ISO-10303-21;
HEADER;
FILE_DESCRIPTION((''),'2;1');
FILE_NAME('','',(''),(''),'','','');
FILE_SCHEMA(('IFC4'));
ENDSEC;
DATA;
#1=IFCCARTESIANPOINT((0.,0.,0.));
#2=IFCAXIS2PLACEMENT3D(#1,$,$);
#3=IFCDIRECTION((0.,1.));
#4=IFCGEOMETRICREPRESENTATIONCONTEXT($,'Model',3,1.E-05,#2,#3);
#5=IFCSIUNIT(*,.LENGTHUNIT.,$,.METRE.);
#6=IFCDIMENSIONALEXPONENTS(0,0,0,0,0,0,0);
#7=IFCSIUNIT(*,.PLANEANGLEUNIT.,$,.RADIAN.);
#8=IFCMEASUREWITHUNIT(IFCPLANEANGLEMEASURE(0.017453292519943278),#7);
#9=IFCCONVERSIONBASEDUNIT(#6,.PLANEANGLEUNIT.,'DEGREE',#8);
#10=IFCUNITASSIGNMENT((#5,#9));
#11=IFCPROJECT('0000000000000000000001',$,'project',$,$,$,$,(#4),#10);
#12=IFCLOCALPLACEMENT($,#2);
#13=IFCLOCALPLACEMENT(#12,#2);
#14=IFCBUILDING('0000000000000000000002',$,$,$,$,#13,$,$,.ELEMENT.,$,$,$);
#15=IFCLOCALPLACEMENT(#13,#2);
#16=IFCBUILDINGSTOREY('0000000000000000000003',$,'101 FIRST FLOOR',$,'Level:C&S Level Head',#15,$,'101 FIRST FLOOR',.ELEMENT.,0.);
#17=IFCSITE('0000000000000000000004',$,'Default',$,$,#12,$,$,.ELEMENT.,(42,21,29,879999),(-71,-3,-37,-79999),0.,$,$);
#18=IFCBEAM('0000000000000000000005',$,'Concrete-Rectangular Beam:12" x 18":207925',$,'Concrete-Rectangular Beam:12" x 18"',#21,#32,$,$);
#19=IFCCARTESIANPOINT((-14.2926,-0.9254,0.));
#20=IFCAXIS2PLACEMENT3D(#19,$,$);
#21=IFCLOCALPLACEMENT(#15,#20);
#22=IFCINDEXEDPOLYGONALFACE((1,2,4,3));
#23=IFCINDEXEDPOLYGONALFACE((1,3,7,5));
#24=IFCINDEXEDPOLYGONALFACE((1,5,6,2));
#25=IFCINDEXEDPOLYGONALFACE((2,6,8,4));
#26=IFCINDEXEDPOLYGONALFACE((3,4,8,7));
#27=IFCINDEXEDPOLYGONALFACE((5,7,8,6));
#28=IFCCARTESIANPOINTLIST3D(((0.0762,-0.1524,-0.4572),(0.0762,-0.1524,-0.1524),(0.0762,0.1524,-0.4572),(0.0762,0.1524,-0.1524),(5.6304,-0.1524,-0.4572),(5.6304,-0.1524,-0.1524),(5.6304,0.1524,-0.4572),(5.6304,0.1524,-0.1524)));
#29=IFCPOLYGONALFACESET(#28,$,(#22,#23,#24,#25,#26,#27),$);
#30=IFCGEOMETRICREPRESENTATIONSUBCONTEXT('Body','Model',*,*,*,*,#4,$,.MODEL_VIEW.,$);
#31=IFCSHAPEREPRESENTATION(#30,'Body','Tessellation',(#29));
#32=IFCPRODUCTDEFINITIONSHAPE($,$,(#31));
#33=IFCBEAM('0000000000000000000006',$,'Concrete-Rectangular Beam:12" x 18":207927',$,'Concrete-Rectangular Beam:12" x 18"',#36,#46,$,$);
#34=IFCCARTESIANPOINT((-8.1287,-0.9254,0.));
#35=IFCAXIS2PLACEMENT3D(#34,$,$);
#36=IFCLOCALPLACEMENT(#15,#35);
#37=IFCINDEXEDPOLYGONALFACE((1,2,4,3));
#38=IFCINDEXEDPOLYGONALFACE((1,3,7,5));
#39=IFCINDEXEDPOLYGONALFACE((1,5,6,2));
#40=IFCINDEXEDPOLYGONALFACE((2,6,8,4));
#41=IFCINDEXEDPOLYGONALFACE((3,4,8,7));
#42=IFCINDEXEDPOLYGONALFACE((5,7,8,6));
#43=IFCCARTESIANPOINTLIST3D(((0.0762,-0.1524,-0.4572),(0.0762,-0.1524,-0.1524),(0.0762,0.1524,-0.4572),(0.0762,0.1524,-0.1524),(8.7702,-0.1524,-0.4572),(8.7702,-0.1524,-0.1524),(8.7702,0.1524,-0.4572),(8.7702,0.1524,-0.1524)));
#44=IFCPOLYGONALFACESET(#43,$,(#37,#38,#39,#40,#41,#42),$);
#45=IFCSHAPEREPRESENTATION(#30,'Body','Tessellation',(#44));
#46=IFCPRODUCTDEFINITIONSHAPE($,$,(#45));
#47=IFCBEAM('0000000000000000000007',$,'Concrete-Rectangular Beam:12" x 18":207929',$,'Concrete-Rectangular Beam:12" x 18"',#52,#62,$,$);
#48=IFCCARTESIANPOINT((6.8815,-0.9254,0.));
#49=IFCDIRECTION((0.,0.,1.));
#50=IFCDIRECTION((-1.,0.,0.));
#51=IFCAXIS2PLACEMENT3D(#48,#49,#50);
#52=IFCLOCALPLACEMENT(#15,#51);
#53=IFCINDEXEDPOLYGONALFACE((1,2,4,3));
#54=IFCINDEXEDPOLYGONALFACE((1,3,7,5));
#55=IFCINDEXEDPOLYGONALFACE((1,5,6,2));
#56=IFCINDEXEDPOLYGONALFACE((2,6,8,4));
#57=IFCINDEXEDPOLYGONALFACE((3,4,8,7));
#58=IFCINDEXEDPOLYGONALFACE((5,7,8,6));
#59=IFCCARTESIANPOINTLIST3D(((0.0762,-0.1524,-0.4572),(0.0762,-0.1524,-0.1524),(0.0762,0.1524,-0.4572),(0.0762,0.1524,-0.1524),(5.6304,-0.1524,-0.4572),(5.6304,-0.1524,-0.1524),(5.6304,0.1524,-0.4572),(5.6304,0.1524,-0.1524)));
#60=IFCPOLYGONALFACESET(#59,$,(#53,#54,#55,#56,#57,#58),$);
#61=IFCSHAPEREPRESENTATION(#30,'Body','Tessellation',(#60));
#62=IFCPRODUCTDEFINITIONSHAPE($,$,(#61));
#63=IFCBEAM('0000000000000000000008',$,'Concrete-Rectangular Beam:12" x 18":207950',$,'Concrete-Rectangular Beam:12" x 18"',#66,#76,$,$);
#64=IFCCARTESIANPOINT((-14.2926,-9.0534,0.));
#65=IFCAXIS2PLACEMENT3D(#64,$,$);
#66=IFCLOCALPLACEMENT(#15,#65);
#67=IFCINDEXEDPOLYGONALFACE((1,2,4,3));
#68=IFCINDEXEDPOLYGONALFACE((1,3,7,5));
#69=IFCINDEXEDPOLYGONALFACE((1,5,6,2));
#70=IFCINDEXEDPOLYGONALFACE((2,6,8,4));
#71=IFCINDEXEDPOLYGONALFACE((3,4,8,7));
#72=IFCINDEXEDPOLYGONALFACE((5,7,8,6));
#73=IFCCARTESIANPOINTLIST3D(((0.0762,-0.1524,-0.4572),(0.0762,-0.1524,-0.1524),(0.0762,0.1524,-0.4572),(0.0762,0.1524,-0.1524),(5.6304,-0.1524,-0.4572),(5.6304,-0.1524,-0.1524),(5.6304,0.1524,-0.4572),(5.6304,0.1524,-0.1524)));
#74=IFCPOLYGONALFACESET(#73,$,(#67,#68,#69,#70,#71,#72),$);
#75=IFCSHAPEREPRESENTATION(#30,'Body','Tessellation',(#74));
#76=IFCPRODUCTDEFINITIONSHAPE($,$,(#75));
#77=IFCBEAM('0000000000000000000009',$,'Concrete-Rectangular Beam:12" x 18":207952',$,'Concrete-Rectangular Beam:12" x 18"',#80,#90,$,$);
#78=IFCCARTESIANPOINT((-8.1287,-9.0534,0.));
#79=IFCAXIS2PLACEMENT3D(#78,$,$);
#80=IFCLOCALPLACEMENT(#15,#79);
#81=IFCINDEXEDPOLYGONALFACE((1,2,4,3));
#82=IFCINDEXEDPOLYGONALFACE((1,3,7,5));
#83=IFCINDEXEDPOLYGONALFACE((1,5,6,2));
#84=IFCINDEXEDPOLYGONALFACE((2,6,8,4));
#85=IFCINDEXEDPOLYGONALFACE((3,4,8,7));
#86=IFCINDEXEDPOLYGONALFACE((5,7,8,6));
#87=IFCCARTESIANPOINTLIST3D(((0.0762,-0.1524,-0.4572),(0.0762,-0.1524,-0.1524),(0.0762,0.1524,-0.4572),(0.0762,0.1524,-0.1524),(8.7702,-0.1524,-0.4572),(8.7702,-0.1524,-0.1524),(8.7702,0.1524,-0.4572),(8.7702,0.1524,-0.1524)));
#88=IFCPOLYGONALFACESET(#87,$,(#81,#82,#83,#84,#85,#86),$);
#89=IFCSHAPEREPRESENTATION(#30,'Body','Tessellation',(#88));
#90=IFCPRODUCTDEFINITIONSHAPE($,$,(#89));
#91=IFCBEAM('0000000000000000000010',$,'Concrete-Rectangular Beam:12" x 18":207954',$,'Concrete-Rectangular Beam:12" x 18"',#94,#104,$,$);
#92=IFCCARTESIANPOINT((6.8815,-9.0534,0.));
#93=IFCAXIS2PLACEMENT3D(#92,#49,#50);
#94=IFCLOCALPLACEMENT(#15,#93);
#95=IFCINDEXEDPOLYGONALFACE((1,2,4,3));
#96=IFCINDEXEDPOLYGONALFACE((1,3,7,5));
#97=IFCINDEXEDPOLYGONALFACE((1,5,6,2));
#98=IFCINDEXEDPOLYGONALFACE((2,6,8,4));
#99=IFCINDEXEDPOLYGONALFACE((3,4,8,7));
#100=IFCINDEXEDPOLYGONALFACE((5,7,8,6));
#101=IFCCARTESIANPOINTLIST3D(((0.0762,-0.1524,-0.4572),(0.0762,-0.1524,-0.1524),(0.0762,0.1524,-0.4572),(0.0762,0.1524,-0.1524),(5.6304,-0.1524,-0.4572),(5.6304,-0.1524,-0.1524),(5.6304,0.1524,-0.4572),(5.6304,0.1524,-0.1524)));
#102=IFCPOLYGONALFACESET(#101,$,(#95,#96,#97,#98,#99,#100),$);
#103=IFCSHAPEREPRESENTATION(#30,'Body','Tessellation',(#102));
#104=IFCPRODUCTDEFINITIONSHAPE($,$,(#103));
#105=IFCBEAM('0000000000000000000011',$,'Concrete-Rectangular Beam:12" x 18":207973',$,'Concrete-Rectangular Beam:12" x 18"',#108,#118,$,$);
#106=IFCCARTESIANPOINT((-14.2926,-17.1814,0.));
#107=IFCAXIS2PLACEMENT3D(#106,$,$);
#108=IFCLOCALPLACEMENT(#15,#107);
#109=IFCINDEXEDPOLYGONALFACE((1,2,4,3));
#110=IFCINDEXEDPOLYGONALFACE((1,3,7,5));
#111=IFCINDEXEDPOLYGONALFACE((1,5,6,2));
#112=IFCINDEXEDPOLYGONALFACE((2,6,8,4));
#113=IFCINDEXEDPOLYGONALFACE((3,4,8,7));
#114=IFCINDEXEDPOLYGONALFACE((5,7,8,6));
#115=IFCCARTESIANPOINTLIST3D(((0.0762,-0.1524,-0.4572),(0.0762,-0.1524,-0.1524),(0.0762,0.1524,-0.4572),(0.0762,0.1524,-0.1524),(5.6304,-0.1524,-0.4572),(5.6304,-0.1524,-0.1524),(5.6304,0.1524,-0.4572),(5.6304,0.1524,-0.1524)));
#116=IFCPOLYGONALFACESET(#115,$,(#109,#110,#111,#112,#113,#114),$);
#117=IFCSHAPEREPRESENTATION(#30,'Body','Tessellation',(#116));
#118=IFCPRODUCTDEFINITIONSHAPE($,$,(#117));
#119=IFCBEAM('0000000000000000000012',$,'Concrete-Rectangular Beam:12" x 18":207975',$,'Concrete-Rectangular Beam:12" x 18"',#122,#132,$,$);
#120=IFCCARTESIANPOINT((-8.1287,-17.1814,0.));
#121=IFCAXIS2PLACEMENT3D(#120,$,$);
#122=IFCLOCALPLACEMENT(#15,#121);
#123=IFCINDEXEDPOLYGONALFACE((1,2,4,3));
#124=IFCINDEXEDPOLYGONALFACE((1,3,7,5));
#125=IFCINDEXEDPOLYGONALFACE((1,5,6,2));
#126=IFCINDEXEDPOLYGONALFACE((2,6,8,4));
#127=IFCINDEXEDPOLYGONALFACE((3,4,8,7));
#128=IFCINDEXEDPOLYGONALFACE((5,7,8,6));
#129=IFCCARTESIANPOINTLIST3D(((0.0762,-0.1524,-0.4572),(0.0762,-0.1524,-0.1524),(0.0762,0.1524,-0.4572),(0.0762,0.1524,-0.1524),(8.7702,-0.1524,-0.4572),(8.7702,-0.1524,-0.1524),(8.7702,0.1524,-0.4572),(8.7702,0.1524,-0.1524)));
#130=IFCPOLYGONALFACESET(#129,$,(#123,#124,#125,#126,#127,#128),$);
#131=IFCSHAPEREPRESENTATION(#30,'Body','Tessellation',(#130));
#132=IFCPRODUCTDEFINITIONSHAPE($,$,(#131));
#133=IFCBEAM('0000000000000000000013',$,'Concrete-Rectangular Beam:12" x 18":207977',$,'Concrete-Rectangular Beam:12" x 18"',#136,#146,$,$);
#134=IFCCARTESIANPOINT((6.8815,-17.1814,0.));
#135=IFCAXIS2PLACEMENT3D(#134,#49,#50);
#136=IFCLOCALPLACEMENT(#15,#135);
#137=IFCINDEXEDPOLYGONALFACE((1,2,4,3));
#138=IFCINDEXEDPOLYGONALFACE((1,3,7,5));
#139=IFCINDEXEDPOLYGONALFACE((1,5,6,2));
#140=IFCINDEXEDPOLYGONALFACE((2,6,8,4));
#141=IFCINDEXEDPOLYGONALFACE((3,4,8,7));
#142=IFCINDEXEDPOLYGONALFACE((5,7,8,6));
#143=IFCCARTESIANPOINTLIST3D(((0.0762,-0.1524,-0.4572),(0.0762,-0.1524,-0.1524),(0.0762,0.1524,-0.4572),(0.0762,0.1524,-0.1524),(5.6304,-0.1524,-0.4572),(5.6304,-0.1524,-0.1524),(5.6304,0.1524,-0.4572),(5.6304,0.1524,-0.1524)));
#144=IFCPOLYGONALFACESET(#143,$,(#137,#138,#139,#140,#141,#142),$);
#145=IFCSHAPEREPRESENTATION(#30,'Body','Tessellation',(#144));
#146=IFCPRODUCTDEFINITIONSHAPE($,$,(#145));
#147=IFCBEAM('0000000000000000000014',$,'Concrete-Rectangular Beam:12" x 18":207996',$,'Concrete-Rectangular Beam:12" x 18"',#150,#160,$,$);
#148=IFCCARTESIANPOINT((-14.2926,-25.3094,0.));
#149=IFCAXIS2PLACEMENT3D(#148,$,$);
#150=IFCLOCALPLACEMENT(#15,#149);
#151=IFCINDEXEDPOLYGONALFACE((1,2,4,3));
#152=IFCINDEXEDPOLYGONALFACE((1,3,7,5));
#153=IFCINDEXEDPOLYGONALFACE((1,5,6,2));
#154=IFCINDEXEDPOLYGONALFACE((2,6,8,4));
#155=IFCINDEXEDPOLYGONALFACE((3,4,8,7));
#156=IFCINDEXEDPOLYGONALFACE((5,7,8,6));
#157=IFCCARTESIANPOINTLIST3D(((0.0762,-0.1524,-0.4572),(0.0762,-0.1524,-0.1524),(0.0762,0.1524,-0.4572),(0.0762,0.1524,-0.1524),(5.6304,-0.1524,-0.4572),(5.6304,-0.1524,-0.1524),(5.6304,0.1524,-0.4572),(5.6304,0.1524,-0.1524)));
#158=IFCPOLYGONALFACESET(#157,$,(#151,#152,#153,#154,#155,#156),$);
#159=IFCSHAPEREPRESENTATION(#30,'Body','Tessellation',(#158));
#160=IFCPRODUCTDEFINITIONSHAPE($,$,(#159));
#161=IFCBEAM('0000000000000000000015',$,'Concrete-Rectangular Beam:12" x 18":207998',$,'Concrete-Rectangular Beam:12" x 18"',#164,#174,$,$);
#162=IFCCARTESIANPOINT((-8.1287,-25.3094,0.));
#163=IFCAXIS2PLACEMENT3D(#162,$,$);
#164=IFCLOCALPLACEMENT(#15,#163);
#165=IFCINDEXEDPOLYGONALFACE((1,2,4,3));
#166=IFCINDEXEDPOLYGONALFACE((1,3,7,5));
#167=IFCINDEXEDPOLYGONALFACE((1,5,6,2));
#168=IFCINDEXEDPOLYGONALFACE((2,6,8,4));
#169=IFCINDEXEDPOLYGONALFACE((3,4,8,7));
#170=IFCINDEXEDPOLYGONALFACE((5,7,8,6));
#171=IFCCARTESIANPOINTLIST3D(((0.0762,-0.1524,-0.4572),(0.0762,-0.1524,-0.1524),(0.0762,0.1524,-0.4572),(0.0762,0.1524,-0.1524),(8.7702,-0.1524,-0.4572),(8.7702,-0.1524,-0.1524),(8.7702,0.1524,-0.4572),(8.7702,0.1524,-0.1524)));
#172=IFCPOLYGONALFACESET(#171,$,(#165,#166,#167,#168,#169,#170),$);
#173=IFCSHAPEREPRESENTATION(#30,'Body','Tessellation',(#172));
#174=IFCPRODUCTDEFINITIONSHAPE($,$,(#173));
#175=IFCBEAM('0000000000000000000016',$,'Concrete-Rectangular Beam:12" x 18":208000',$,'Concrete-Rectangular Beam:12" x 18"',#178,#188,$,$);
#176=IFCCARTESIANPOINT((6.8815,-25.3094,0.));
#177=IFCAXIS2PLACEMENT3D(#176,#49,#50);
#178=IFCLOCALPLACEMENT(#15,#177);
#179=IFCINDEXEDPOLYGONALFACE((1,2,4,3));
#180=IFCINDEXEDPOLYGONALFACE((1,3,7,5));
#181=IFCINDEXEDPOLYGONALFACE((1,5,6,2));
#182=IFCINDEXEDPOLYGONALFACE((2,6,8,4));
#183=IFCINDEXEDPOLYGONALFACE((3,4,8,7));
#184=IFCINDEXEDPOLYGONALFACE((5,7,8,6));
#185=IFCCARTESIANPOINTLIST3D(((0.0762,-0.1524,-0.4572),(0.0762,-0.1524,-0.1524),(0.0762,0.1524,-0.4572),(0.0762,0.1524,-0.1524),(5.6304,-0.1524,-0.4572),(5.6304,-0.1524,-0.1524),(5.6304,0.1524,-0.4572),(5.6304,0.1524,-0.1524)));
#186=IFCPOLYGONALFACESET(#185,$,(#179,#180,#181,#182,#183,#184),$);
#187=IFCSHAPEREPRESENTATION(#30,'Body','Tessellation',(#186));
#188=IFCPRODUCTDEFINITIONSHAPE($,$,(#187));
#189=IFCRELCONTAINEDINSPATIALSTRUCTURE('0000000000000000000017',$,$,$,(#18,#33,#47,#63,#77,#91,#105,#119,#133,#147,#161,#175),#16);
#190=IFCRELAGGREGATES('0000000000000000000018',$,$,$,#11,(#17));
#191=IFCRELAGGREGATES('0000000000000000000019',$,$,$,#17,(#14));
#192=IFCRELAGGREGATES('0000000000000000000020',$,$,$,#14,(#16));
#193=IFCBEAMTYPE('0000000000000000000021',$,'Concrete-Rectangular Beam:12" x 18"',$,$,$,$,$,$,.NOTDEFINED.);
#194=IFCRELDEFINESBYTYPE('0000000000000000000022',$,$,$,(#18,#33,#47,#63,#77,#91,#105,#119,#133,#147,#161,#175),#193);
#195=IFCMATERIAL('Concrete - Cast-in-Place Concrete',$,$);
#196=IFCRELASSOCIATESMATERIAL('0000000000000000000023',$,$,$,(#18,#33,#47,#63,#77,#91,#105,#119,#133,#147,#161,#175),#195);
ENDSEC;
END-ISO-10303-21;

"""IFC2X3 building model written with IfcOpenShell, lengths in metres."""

from ifc_helpers import new_model, entity, si_unit, converted_unit, direction, frame, frame_2d, origin, place, context, subcontext, project, spatial, rectangle, extrude, material, type_object, element, save


model = new_model("IFC2X3")

# Units and contexts
model_context = context("Model", 3, precision=1e-05, world=origin(), true_north=direction((0.0, 1.0)))
body_context = subcontext(model_context, "Body", "Model", "MODEL_VIEW")
ifc_project = project(units=[si_unit("LENGTHUNIT", "METRE"), converted_unit("PLANEANGLEUNIT", "DEGREE", entity("IfcPlaneAngleMeasure", 0.017453292519943278), si_unit("PLANEANGLEUNIT", "RADIAN"), dimensions=[0, 0, 0, 0, 0, 0, 0])], contexts=[model_context])

# Site, building, storey
site_placement = place(None, origin())
site = spatial("IfcSite", under=ifc_project, at=site_placement, Name="Default", CompositionType="ELEMENT", RefLatitude=(42, 21, 29, 879999), RefLongitude=(-71, -3, -37, -79999), RefElevation=0.0)
building_placement = place(site_placement, origin())
building = spatial("IfcBuilding", under=site, at=building_placement, CompositionType="ELEMENT")
storey_placement = place(building_placement, origin())
storey = spatial("IfcBuildingStorey", under=building, at=storey_placement, Name="101 FIRST FLOOR", ObjectType="Level:C&S Level Head", LongName="101 FIRST FLOOR", CompositionType="ELEMENT", Elevation=0.0)

# Beams
ifc_material = material(Name="Concrete - Cast-in-Place Concrete")
beam_type = type_object("IfcBeamType", Name="Concrete-Rectangular Beam:12\" x 18\"", PredefinedType="NOTDEFINED")
beam_1_placement = place(storey_placement, frame((-14.2926, -0.9254, 0.0)))
element("IfcBeam", 1, at=beam_1_placement, inside=storey, type_object=beam_type, material=ifc_material, Name="Concrete-Rectangular Beam:12\" x 18\":207925", ObjectType="Concrete-Rectangular Beam:12\" x 18\"", context=body_context, shape_type="SweptSolid", body=[
    extrude(rectangle(XDim=0.3048, YDim=0.3048, at=frame_2d((0.0, 0.0), x_axis=(1.0, 0.0))), frame((0.0762, 0.0, -0.3048), z_axis=(1.0, 0.0, 0.0), x_axis=(0.0, 0.0, -1.0)), (0.0, 0.0, 1.0), 5.5542),
])
beam_2_placement = place(storey_placement, frame((-8.1287, -0.9254, 0.0)))
element("IfcBeam", 2, at=beam_2_placement, inside=storey, type_object=beam_type, material=ifc_material, Name="Concrete-Rectangular Beam:12\" x 18\":207927", ObjectType="Concrete-Rectangular Beam:12\" x 18\"", context=body_context, shape_type="SweptSolid", body=[
    extrude(rectangle(XDim=0.3048, YDim=0.3048, at=frame_2d((0.0, 0.0), x_axis=(1.0, 0.0))), frame((0.0762, 0.0, -0.3048), z_axis=(1.0, 0.0, 0.0), x_axis=(0.0, 0.0, -1.0)), (0.0, 0.0, 1.0), 8.694),
])
beam_3_placement = place(storey_placement, frame((6.8815, -0.9254, 0.0), z_axis=(0.0, 0.0, 1.0), x_axis=(-1.0, 0.0, 0.0)))
element("IfcBeam", 3, at=beam_3_placement, inside=storey, type_object=beam_type, material=ifc_material, Name="Concrete-Rectangular Beam:12\" x 18\":207929", ObjectType="Concrete-Rectangular Beam:12\" x 18\"", context=body_context, shape_type="SweptSolid", body=[
    extrude(rectangle(XDim=0.3048, YDim=0.3048, at=frame_2d((0.0, 0.0), x_axis=(1.0, 0.0))), frame((0.0762, 0.0, -0.3048), z_axis=(1.0, 0.0, 0.0), x_axis=(0.0, 0.0, -1.0)), (0.0, 0.0, 1.0), 5.5542),
])
beam_4_placement = place(storey_placement, frame((-14.2926, -9.0534, 0.0)))
element("IfcBeam", 4, at=beam_4_placement, inside=storey, type_object=beam_type, material=ifc_material, Name="Concrete-Rectangular Beam:12\" x 18\":207950", ObjectType="Concrete-Rectangular Beam:12\" x 18\"", context=body_context, shape_type="SweptSolid", body=[
    extrude(rectangle(XDim=0.3048, YDim=0.3048, at=frame_2d((0.0, 0.0), x_axis=(1.0, 0.0))), frame((0.0762, 0.0, -0.3048), z_axis=(1.0, 0.0, 0.0), x_axis=(0.0, 0.0, -1.0)), (0.0, 0.0, 1.0), 5.5542),
])
beam_5_placement = place(storey_placement, frame((-8.1287, -9.0534, 0.0)))
element("IfcBeam", 5, at=beam_5_placement, inside=storey, type_object=beam_type, material=ifc_material, Name="Concrete-Rectangular Beam:12\" x 18\":207952", ObjectType="Concrete-Rectangular Beam:12\" x 18\"", context=body_context, shape_type="SweptSolid", body=[
    extrude(rectangle(XDim=0.3048, YDim=0.3048, at=frame_2d((0.0, 0.0), x_axis=(1.0, 0.0))), frame((0.0762, 0.0, -0.3048), z_axis=(1.0, 0.0, 0.0), x_axis=(0.0, 0.0, -1.0)), (0.0, 0.0, 1.0), 8.694),
])
beam_6_placement = place(storey_placement, frame((6.8815, -9.0534, 0.0), z_axis=(0.0, 0.0, 1.0), x_axis=(-1.0, 0.0, 0.0)))
element("IfcBeam", 6, at=beam_6_placement, inside=storey, type_object=beam_type, material=ifc_material, Name="Concrete-Rectangular Beam:12\" x 18\":207954", ObjectType="Concrete-Rectangular Beam:12\" x 18\"", context=body_context, shape_type="SweptSolid", body=[
    extrude(rectangle(XDim=0.3048, YDim=0.3048, at=frame_2d((0.0, 0.0), x_axis=(1.0, 0.0))), frame((0.0762, 0.0, -0.3048), z_axis=(1.0, 0.0, 0.0), x_axis=(0.0, 0.0, -1.0)), (0.0, 0.0, 1.0), 5.5542),
])
beam_7_placement = place(storey_placement, frame((-14.2926, -17.1814, 0.0)))
element("IfcBeam", 7, at=beam_7_placement, inside=storey, type_object=beam_type, material=ifc_material, Name="Concrete-Rectangular Beam:12\" x 18\":207973", ObjectType="Concrete-Rectangular Beam:12\" x 18\"", context=body_context, shape_type="SweptSolid", body=[
    extrude(rectangle(XDim=0.3048, YDim=0.3048, at=frame_2d((0.0, 0.0), x_axis=(1.0, 0.0))), frame((0.0762, 0.0, -0.3048), z_axis=(1.0, 0.0, 0.0), x_axis=(0.0, 0.0, -1.0)), (0.0, 0.0, 1.0), 5.5542),
])
beam_8_placement = place(storey_placement, frame((-8.1287, -17.1814, 0.0)))
element("IfcBeam", 8, at=beam_8_placement, inside=storey, type_object=beam_type, material=ifc_material, Name="Concrete-Rectangular Beam:12\" x 18\":207975", ObjectType="Concrete-Rectangular Beam:12\" x 18\"", context=body_context, shape_type="SweptSolid", body=[
    extrude(rectangle(XDim=0.3048, YDim=0.3048, at=frame_2d((0.0, 0.0), x_axis=(1.0, 0.0))), frame((0.0762, 0.0, -0.3048), z_axis=(1.0, 0.0, 0.0), x_axis=(0.0, 0.0, -1.0)), (0.0, 0.0, 1.0), 8.694),
])
beam_9_placement = place(storey_placement, frame((6.8815, -17.1814, 0.0), z_axis=(0.0, 0.0, 1.0), x_axis=(-1.0, 0.0, 0.0)))
element("IfcBeam", 9, at=beam_9_placement, inside=storey, type_object=beam_type, material=ifc_material, Name="Concrete-Rectangular Beam:12\" x 18\":207977", ObjectType="Concrete-Rectangular Beam:12\" x 18\"", context=body_context, shape_type="SweptSolid", body=[
    extrude(rectangle(XDim=0.3048, YDim=0.3048, at=frame_2d((0.0, 0.0), x_axis=(1.0, 0.0))), frame((0.0762, 0.0, -0.3048), z_axis=(1.0, 0.0, 0.0), x_axis=(0.0, 0.0, -1.0)), (0.0, 0.0, 1.0), 5.5542),
])
beam_10_placement = place(storey_placement, frame((-14.2926, -25.3094, 0.0)))
element("IfcBeam", 10, at=beam_10_placement, inside=storey, type_object=beam_type, material=ifc_material, Name="Concrete-Rectangular Beam:12\" x 18\":207996", ObjectType="Concrete-Rectangular Beam:12\" x 18\"", context=body_context, shape_type="SweptSolid", body=[
    extrude(rectangle(XDim=0.3048, YDim=0.3048, at=frame_2d((0.0, 0.0), x_axis=(1.0, 0.0))), frame((0.0762, 0.0, -0.3048), z_axis=(1.0, 0.0, 0.0), x_axis=(0.0, 0.0, -1.0)), (0.0, 0.0, 1.0), 5.5542),
])
beam_11_placement = place(storey_placement, frame((-8.1287, -25.3094, 0.0)))
element("IfcBeam", 11, at=beam_11_placement, inside=storey, type_object=beam_type, material=ifc_material, Name="Concrete-Rectangular Beam:12\" x 18\":207998", ObjectType="Concrete-Rectangular Beam:12\" x 18\"", context=body_context, shape_type="SweptSolid", body=[
    extrude(rectangle(XDim=0.3048, YDim=0.3048, at=frame_2d((0.0, 0.0), x_axis=(1.0, 0.0))), frame((0.0762, 0.0, -0.3048), z_axis=(1.0, 0.0, 0.0), x_axis=(0.0, 0.0, -1.0)), (0.0, 0.0, 1.0), 8.694),
])
beam_12_placement = place(storey_placement, frame((6.8815, -25.3094, 0.0), z_axis=(0.0, 0.0, 1.0), x_axis=(-1.0, 0.0, 0.0)))
element("IfcBeam", 12, at=beam_12_placement, inside=storey, type_object=beam_type, material=ifc_material, Name="Concrete-Rectangular Beam:12\" x 18\":208000", ObjectType="Concrete-Rectangular Beam:12\" x 18\"", context=body_context, shape_type="SweptSolid", body=[
    extrude(rectangle(XDim=0.3048, YDim=0.3048, at=frame_2d((0.0, 0.0), x_axis=(1.0, 0.0))), frame((0.0762, 0.0, -0.3048), z_axis=(1.0, 0.0, 0.0), x_axis=(0.0, 0.0, -1.0)), (0.0, 0.0, 1.0), 5.5542),
])

save(model, "model.ifc")
